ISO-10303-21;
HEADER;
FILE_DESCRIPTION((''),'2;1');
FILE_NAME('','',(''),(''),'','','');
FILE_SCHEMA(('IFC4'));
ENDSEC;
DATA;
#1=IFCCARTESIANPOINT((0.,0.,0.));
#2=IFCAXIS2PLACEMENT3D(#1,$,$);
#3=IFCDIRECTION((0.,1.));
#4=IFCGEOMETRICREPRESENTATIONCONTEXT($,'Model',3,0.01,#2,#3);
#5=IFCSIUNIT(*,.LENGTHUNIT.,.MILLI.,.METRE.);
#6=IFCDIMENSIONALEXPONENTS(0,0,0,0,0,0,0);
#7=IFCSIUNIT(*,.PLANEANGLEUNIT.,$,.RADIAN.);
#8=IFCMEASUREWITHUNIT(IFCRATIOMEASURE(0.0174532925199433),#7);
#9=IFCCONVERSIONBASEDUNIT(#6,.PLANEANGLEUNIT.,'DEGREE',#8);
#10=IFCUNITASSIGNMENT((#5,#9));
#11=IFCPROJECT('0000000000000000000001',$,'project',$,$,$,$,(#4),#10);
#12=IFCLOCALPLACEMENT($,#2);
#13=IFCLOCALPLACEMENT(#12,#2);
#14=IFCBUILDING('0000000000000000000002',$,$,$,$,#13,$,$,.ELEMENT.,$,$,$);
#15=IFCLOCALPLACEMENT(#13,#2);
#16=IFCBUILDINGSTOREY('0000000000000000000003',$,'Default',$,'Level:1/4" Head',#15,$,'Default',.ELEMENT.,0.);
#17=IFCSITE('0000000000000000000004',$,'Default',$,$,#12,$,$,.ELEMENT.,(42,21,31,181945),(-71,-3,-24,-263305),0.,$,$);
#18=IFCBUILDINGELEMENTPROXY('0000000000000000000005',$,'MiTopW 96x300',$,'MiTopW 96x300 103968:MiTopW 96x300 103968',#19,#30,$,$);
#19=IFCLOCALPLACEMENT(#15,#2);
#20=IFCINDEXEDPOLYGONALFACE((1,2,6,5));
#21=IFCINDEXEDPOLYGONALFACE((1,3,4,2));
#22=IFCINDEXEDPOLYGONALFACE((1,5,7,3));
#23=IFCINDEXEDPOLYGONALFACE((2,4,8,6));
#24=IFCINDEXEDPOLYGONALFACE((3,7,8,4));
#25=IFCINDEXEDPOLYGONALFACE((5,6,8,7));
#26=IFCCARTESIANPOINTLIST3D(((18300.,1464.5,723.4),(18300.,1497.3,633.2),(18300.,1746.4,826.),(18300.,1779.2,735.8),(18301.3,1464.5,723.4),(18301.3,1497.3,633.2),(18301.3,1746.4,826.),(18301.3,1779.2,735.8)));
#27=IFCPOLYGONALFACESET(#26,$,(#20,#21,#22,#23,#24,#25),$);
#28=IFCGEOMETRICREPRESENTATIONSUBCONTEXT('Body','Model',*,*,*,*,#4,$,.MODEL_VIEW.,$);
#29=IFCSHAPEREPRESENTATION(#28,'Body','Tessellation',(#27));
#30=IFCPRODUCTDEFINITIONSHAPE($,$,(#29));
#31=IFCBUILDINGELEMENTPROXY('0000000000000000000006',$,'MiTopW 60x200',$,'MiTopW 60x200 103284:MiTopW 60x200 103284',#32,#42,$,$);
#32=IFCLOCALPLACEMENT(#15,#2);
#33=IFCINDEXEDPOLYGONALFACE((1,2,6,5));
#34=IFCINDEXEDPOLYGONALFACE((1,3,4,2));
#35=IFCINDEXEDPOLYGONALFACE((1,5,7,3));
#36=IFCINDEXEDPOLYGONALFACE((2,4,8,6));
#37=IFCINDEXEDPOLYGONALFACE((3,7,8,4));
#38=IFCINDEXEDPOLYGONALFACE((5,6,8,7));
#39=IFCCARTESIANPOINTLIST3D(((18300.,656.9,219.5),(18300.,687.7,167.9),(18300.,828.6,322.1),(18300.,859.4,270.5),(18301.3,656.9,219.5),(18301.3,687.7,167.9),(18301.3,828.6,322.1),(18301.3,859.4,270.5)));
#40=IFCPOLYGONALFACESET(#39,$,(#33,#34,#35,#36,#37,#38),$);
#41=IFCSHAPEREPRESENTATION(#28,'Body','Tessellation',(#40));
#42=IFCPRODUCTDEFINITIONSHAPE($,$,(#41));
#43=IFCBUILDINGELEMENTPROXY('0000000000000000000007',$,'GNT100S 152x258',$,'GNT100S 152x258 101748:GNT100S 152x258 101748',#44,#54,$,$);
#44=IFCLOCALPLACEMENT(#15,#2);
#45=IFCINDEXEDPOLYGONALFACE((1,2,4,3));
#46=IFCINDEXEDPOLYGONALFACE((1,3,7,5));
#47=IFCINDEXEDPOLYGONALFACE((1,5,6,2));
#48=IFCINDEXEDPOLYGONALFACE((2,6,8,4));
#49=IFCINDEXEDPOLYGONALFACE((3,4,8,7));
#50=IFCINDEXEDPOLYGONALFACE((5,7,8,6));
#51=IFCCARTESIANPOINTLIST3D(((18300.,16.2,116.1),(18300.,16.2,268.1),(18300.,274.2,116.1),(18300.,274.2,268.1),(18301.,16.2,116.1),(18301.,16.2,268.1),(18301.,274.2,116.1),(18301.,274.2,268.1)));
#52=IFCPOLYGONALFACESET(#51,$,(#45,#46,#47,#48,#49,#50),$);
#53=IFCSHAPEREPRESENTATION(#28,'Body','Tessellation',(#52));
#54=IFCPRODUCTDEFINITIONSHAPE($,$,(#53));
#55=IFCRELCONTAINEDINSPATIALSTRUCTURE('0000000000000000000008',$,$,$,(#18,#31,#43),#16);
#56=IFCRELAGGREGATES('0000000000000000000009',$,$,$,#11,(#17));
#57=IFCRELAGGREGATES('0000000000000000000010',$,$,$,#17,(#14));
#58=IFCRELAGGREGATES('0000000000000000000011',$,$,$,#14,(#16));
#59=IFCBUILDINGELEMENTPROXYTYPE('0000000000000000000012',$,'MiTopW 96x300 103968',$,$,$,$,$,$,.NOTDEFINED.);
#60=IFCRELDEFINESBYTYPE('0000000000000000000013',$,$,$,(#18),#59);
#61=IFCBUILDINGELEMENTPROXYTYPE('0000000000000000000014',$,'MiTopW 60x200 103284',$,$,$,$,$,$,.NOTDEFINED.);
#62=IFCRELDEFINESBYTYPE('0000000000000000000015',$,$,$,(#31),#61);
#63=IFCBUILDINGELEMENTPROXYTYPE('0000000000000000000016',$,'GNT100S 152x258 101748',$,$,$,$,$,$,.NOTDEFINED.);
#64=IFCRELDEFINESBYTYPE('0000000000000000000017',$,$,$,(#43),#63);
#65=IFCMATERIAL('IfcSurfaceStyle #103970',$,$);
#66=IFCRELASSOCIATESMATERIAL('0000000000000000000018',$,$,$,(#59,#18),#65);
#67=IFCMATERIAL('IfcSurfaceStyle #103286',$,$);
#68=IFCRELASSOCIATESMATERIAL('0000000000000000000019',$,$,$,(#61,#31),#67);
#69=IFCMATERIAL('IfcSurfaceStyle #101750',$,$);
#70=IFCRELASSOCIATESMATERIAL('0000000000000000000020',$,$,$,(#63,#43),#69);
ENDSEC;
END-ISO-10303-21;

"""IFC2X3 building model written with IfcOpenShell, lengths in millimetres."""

from ifc_helpers import new_model, entity, si_unit, converted_unit, direction, frame, origin, origin_2d_with_axis, place, context, subcontext, project, spatial, polyline, rectangle, outline, extrude, source, transform, mapped, material, type_object, type_shapes, element, save


model = new_model("IFC2X3")

# Units and contexts
model_context = context("Model", 3, precision=0.01, world=origin(), true_north=direction((0.0, 1.0)))
body_context = subcontext(model_context, "Body", "Model", "MODEL_VIEW")
ifc_project = project(units=[si_unit("LENGTHUNIT", "METRE", prefix="MILLI"), converted_unit("PLANEANGLEUNIT", "DEGREE", entity("IfcRatioMeasure", 0.0174532925199433), si_unit("PLANEANGLEUNIT", "RADIAN"), dimensions=[0, 0, 0, 0, 0, 0, 0])], contexts=[model_context])

# Site, building, storey
site_placement = place(None, origin())
site = spatial("IfcSite", under=ifc_project, at=site_placement, Name="Default", CompositionType="ELEMENT", RefLatitude=(42, 21, 31, 181945), RefLongitude=(-71, -3, -24, -263305), RefElevation=0.0)
building_placement = place(site_placement, origin())
building = spatial("IfcBuilding", under=site, at=building_placement, CompositionType="ELEMENT")
storey_placement = place(building_placement, origin())
storey = spatial("IfcBuildingStorey", under=building, at=storey_placement, Name="Default", ObjectType="Level:1/4\" Head", LongName="Default", CompositionType="ELEMENT", Elevation=0.0)

# Building element proxies
ifc_material_1 = material(Name="IfcSurfaceStyle #103970")
building_element_proxy_type_1 = type_object("IfcBuildingElementProxyType", Name="MiTopW 96x300 103968", PredefinedType="NOTDEFINED", material=ifc_material_1)
shared_shape_1 = source(origin(), body_context, "Body", "SweptSolid", [
    extrude(outline(polyline([(-150.0, -48.0), (150.0, -48.0), (150.0, 48.0), (-150.0, 48.0), (-150.0, -48.0)])), frame((150.0, 48.0, 0.0), z_axis=(0.0, 0.0, 1.0), x_axis=(-1.0, 0.0, 0.0)), (0.0, 0.0, 1.0), 1.3),
])
type_shapes(building_element_proxy_type_1, [shared_shape_1])
proxy_1_placement = place(building_placement, frame((18301.3, 1464.5, 723.4), z_axis=(-1.0, 0.0, 0.0), x_axis=(0.0, 0.939693, 0.34202)))
element("IfcBuildingElementProxy", 1, at=proxy_1_placement, inside=storey, type_object=building_element_proxy_type_1, material=ifc_material_1, Name="MiTopW 96x300", ObjectType="MiTopW 96x300 103968:MiTopW 96x300 103968", context=body_context, shape_type="MappedRepresentation", body=[
    mapped(shared_shape_1, transform((0.0, 0.0, 0.0), scale=1.0)),
])
ifc_material_2 = material(Name="IfcSurfaceStyle #103286")
building_element_proxy_type_2 = type_object("IfcBuildingElementProxyType", Name="MiTopW 60x200 103284", PredefinedType="NOTDEFINED", material=ifc_material_2)
shared_shape_2 = source(origin(), body_context, "Body", "SweptSolid", [
    extrude(outline(polyline([(-100.0, -30.0), (100.0, -30.0), (100.0, 30.0), (-100.0, 30.0), (-100.0, -30.0)])), frame((100.0, 30.0, 0.0), z_axis=(0.0, 0.0, 1.0), x_axis=(-1.0, 0.0, 0.0)), (0.0, 0.0, 1.0), 1.3),
])
type_shapes(building_element_proxy_type_2, [shared_shape_2])
proxy_2_placement = place(building_placement, frame((18301.3, 656.9, 219.5), z_axis=(-1.0, 0.0, 0.0), x_axis=(0.0, 0.858392, 0.512994)))
element("IfcBuildingElementProxy", 2, at=proxy_2_placement, inside=storey, type_object=building_element_proxy_type_2, material=ifc_material_2, Name="MiTopW 60x200", ObjectType="MiTopW 60x200 103284:MiTopW 60x200 103284", context=body_context, shape_type="MappedRepresentation", body=[
    mapped(shared_shape_2, transform((0.0, 0.0, 0.0), scale=1.0)),
])
ifc_material_3 = material(Name="IfcSurfaceStyle #101750")
building_element_proxy_type_3 = type_object("IfcBuildingElementProxyType", Name="GNT100S 152x258 101748", PredefinedType="NOTDEFINED", material=ifc_material_3)
shared_shape_3 = source(origin(), body_context, "Body", "SweptSolid", [
    extrude(rectangle(XDim=258.0, YDim=152.0, at=origin_2d_with_axis()), frame((129.0, 76.0, 0.0), z_axis=(0.0, 0.0, 1.0), x_axis=(-1.0, 0.0, 0.0)), (0.0, 0.0, 1.0), 1.0),
])
type_shapes(building_element_proxy_type_3, [shared_shape_3])
proxy_3_placement = place(building_placement, frame((18301.0, 16.2, 268.1), z_axis=(-1.0, 0.0, 0.0), x_axis=(0.0, 1.0, 0.0)))
element("IfcBuildingElementProxy", 3, at=proxy_3_placement, inside=storey, type_object=building_element_proxy_type_3, material=ifc_material_3, Name="GNT100S 152x258", ObjectType="GNT100S 152x258 101748:GNT100S 152x258 101748", context=body_context, shape_type="MappedRepresentation", body=[
    mapped(shared_shape_3, transform((0.0, 0.0, 0.0), scale=1.0)),
])

save(model, "model.ifc")
